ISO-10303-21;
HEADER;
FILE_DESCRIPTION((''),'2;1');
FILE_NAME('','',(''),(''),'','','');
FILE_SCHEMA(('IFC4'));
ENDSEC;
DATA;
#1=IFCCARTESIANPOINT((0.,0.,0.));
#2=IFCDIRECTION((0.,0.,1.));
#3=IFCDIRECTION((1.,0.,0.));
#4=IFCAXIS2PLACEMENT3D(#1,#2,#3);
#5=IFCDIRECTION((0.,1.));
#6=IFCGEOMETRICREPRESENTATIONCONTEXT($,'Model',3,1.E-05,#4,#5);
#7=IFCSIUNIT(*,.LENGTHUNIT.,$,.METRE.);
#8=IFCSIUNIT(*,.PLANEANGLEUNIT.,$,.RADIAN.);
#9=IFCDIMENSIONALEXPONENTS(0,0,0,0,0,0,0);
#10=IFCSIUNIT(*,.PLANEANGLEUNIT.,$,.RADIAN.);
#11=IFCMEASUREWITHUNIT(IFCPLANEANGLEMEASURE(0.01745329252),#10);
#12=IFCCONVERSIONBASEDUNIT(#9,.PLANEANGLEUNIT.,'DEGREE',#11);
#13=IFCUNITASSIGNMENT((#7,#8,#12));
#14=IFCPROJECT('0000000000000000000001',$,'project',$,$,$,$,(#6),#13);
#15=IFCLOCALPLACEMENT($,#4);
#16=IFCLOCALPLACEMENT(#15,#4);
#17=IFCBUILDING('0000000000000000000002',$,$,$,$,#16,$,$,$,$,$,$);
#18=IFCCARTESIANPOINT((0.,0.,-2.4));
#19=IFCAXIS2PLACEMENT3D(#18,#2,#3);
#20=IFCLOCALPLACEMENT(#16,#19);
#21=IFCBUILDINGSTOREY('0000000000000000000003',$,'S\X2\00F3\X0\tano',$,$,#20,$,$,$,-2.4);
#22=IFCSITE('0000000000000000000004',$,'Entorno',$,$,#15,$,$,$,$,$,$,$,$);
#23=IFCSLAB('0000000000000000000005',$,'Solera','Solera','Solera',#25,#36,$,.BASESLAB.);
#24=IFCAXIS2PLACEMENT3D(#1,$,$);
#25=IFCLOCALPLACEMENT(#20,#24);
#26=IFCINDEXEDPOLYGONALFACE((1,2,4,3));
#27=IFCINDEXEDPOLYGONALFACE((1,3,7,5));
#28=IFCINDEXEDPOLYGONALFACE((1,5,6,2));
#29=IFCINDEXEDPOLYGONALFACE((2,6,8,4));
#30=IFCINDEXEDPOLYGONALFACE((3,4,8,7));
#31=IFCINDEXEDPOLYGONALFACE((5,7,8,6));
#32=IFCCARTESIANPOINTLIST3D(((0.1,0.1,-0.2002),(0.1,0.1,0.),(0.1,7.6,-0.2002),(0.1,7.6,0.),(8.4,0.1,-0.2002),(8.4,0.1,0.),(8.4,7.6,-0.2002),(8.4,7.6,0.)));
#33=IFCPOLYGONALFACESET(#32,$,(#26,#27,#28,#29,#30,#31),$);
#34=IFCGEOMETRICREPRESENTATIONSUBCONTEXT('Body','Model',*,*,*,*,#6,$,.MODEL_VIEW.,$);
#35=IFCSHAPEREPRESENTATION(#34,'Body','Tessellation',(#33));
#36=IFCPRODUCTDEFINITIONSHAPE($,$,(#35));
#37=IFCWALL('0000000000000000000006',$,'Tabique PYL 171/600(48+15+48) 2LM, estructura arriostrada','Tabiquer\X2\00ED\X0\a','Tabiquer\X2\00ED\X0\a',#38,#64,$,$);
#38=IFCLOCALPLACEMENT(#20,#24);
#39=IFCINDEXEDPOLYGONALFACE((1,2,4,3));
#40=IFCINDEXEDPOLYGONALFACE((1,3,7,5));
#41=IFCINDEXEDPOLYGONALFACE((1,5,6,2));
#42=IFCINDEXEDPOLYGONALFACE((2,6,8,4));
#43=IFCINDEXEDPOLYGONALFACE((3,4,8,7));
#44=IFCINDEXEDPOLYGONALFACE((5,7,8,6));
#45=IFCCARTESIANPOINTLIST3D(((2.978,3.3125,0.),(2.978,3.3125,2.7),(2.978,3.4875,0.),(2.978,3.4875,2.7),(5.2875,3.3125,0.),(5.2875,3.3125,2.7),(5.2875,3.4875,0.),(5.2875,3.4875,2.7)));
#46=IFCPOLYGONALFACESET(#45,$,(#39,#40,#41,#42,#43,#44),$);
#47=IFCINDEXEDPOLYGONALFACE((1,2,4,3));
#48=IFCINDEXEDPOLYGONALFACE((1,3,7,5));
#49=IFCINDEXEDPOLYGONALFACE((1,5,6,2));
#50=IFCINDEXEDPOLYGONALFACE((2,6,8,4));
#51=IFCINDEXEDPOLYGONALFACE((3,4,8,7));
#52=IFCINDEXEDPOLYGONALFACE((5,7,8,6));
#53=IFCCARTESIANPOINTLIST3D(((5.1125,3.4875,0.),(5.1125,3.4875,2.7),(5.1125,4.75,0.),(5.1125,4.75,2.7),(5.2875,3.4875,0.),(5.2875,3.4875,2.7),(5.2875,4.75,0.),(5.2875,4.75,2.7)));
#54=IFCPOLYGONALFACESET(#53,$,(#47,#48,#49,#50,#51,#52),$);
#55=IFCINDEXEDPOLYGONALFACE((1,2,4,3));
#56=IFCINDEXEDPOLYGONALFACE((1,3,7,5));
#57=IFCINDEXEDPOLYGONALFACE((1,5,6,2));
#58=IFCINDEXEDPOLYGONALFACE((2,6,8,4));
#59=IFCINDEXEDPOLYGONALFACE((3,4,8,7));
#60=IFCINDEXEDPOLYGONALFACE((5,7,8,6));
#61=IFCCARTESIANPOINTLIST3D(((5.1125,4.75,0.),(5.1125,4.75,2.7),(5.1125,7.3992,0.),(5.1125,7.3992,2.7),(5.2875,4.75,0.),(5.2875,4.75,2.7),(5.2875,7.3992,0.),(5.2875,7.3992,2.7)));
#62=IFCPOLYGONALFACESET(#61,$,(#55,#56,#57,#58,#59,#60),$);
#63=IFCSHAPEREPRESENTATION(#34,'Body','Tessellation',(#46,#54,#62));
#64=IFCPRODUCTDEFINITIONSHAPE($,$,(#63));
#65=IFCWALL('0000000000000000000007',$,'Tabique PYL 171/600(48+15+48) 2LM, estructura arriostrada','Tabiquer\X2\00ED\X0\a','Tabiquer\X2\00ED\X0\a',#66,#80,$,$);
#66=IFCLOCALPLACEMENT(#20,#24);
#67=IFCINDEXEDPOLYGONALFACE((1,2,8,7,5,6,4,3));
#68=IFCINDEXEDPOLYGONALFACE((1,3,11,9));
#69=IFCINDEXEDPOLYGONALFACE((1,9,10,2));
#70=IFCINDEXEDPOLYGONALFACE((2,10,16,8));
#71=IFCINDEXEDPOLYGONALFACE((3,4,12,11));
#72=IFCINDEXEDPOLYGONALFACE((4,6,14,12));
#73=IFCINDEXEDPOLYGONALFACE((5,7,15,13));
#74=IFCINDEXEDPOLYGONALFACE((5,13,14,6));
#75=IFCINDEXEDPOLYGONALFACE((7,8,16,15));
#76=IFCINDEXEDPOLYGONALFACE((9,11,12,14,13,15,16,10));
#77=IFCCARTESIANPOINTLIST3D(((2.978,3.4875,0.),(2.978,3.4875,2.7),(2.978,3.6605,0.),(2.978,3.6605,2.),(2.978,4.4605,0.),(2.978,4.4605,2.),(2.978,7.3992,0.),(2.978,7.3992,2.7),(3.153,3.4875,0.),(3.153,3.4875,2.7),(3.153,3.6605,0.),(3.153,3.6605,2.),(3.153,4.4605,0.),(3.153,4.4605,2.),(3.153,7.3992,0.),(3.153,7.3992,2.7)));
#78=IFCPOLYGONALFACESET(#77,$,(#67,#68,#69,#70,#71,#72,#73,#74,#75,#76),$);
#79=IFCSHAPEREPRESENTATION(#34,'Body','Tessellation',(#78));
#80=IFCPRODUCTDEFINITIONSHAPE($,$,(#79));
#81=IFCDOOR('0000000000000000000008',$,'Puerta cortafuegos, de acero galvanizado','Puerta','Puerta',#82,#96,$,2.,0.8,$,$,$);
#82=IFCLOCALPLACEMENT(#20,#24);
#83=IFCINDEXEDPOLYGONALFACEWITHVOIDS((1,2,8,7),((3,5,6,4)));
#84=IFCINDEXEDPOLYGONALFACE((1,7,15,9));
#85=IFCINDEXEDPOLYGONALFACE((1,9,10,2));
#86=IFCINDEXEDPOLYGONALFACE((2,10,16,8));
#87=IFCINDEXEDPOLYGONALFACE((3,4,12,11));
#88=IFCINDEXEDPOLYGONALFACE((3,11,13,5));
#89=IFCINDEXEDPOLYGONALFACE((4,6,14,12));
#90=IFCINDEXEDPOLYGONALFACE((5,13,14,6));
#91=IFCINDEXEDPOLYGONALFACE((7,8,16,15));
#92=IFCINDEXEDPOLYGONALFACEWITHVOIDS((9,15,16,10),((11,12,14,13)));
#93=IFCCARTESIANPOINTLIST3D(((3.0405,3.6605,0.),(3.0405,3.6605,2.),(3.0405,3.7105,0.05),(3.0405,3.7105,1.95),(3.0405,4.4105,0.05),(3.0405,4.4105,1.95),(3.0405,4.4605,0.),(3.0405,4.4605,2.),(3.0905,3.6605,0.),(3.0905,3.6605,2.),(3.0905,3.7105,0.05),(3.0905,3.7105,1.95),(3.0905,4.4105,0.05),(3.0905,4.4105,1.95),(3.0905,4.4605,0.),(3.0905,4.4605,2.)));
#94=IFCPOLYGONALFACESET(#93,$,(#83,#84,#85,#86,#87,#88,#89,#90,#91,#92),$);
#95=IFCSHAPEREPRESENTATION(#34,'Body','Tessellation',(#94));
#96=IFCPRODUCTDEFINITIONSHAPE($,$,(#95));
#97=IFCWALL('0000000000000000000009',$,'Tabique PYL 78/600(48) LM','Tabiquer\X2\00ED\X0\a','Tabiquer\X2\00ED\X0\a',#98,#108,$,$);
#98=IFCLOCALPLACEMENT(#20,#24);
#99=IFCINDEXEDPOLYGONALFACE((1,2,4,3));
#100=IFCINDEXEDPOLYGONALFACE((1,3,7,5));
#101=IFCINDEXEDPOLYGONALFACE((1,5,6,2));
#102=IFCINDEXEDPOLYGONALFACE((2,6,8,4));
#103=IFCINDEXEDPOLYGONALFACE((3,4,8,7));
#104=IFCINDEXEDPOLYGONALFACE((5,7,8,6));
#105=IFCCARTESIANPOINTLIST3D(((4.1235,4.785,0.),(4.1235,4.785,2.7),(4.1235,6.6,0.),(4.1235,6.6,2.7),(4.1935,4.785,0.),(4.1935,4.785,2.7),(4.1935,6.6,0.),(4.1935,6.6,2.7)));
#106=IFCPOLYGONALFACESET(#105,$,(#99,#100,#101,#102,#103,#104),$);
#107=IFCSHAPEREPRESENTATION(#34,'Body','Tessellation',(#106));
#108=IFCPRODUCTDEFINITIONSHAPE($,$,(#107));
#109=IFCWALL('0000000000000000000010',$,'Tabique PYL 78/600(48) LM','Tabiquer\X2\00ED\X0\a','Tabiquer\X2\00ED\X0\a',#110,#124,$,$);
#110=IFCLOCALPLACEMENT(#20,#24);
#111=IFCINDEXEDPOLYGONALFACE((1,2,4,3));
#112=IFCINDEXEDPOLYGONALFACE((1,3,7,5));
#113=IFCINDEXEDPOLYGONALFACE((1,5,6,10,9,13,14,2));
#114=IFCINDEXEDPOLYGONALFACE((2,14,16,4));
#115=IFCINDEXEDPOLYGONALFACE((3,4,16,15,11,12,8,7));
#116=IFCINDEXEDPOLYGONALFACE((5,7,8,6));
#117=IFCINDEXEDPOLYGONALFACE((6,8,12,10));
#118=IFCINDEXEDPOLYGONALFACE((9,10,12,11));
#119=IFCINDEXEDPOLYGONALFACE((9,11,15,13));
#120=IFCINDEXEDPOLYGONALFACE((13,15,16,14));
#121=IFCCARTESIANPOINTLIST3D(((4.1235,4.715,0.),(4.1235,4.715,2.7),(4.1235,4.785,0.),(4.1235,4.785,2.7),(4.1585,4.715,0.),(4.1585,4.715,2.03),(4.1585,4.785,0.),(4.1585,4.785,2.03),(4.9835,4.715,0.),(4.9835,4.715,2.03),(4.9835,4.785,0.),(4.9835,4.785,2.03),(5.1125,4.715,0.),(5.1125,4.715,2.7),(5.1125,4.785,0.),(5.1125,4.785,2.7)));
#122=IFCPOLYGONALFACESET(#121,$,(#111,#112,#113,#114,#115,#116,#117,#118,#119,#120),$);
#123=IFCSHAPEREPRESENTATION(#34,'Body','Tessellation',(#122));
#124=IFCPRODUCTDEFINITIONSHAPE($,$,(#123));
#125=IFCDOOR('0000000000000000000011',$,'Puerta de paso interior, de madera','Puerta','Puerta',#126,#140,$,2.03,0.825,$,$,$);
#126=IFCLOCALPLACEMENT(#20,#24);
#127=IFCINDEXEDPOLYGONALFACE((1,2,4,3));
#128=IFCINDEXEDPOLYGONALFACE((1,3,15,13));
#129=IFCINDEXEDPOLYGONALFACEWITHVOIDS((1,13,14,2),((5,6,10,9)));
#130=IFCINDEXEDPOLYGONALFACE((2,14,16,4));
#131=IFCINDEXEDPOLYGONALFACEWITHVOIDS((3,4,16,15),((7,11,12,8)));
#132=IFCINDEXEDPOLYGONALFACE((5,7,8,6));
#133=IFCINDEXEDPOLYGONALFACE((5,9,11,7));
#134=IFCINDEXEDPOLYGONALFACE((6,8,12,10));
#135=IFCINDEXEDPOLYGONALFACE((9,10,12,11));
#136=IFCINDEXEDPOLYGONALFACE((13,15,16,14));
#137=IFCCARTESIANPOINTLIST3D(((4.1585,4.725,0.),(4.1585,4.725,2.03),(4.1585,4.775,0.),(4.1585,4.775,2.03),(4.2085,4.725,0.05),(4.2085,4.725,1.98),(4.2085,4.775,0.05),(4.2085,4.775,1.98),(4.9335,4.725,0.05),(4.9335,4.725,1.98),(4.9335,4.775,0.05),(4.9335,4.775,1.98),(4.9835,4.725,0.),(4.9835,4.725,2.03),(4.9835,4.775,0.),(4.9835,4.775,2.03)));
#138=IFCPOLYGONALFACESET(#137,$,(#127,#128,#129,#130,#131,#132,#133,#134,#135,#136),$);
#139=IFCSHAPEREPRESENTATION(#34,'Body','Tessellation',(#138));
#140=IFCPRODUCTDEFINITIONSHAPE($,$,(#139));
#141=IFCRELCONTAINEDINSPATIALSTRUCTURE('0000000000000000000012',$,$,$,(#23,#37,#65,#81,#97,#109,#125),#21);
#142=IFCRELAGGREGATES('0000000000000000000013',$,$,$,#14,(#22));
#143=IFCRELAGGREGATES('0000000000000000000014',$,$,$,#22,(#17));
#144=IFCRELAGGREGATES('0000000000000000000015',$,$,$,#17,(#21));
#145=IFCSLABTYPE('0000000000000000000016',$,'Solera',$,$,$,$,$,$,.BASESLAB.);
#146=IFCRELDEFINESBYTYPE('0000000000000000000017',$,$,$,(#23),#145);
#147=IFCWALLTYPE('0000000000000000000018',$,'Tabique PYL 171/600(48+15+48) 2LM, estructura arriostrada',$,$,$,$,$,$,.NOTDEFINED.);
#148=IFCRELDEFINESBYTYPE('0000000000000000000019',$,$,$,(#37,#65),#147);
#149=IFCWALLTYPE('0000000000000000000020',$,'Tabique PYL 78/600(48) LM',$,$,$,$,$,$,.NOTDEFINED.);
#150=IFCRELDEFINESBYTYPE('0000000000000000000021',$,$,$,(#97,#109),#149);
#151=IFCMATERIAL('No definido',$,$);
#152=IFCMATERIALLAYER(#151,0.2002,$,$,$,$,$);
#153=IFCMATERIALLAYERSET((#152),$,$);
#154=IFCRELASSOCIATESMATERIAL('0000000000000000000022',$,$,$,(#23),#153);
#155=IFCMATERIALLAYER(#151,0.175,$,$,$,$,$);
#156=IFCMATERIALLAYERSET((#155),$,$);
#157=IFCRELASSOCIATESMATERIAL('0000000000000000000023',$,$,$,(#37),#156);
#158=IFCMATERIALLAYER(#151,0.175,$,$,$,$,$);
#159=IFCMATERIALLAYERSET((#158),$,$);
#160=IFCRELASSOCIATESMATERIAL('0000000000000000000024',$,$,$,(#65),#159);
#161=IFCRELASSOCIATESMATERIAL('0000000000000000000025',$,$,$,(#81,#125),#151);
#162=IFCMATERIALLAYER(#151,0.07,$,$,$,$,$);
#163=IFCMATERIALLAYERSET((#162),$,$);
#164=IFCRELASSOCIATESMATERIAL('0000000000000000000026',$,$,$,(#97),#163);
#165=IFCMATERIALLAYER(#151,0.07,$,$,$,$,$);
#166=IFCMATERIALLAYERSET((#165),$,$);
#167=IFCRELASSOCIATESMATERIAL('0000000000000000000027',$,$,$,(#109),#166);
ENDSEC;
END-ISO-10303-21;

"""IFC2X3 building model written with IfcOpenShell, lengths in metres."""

from ifc_helpers import new_model, entity, si_unit, converted_unit, direction, frame, origin_with_axes, origin_2d_with_axis, place, context, subcontext, project, spatial, polyline, rectangle, hollow_rectangle, outline, extrude, shape, material, layer, layer_set, layer_usage, type_object, element, fill, save


model = new_model("IFC2X3")

# Units and contexts
model_context = context("Model", 3, precision=1e-05, world=origin_with_axes(), true_north=direction((0.0, 1.0)))
body_context = subcontext(model_context, "Body", "Model", "MODEL_VIEW")
footprint_context = subcontext(model_context, "FootPrint", "Model", "MODEL_VIEW")
ifc_project = project(units=[si_unit("LENGTHUNIT", "METRE"), si_unit("PLANEANGLEUNIT", "RADIAN"), converted_unit("PLANEANGLEUNIT", "DEGREE", entity("IfcPlaneAngleMeasure", 0.01745329252), si_unit("PLANEANGLEUNIT", "RADIAN"), dimensions=[0, 0, 0, 0, 0, 0, 0])], contexts=[model_context])

# Site, building, storey
site_placement = place(None, origin_with_axes())
site = spatial("IfcSite", under=ifc_project, at=site_placement, Name="Entorno")
building_placement = place(site_placement, origin_with_axes())
building = spatial("IfcBuilding", under=site, at=building_placement)
storey_placement = place(building_placement, frame((0.0, 0.0, -2.4), z_axis=(0.0, 0.0, 1.0), x_axis=(1.0, 0.0, 0.0)))
storey = spatial("IfcBuildingStorey", under=building, at=storey_placement, Name="Sótano", Elevation=-2.4)

# Slab
ifc_material = material(Name="No definido")
ifc_layer_1 = layer(ifc_material, 0.2002)
ifc_layer_set_1 = layer_set([ifc_layer_1])
ifc_layer_usage_1 = layer_usage(ifc_layer_set_1, "AXIS3", "POSITIVE", 0.0)
slab_type = type_object("IfcSlabType", Name="Solera", PredefinedType="BASESLAB")
slab_placement = place(storey_placement, frame((0.1, 0.1, -0.2002), z_axis=(0.0, 0.0, 1.0), x_axis=(1.0, 0.0, 0.0)))
element("IfcSlab", 1, at=slab_placement, inside=storey, type_object=slab_type, material=ifc_layer_usage_1, Name="Solera", Description="Solera", ObjectType="Solera", PredefinedType="BASESLAB", context=body_context, shape_type="SweptSolid", body=[
    extrude(outline(polyline([(0.0, 0.0), (8.3, 0.0), (8.3, 7.5), (0.0, 7.5), (0.0, 0.0)])), origin_with_axes(), (0.0, 0.0, 1.0), 0.2002),
])

# Wall
ifc_layer_2 = layer(ifc_material, 0.175)
ifc_layer_set_2 = layer_set([ifc_layer_2])
ifc_layer_usage_2 = layer_usage(ifc_layer_set_2, "AXIS2", "POSITIVE", -0.0875)
wall_type_1 = type_object("IfcWallType", Name="Tabique PYL 171/600(48+15+48) 2LM, estructura arriostrada")
wall_1_placement = place(storey_placement, frame((3.0655, 3.4, 0.0), z_axis=(0.0, 0.0, 1.0), x_axis=(1.0, 0.0, 0.0)))
element("IfcWall", 2, at=wall_1_placement, inside=storey, type_object=wall_type_1, material=ifc_layer_usage_2, Name="Tabique PYL 171/600(48+15+48) 2LM, estructura arriostrada", Description="Tabiquería", ObjectType="Tabiquería", context=body_context, shape_type="SolidModel", body=[
    extrude(outline(polyline([(-1.1547, -1.35), (1.1547, -1.35), (1.1547, 1.35), (-1.1547, 1.35), (-1.1547, -1.35)])), frame((1.0673, 0.0875, 1.35), z_axis=(0.0, -1.0, 0.0), x_axis=(1.0, 0.0, 0.0)), (0.0, 0.0, 1.0), 0.175),
    extrude(outline(polyline([(-0.6312, -1.35), (0.6312, -1.35), (0.6312, 1.35), (-0.6312, 1.35), (-0.6312, -1.35)])), frame((2.047, 0.7188, 1.35), z_axis=(1.0, 0.0, 0.0), x_axis=(0.0, 1.0, 0.0)), (0.0, 0.0, 1.0), 0.175),
    extrude(outline(polyline([(-1.3246, -1.35), (1.3246, -1.35), (1.3246, 1.35), (-1.3246, 1.35), (-1.3246, -1.35)])), frame((2.047, 2.6746, 1.35), z_axis=(1.0, 0.0, 0.0), x_axis=(0.0, 1.0, 0.0)), (0.0, 0.0, 1.0), 0.175),
])

# Wall, opening, door
ifc_layer_3 = layer(ifc_material, 0.175)
ifc_layer_set_3 = layer_set([ifc_layer_3])
ifc_layer_usage_3 = layer_usage(ifc_layer_set_3, "AXIS2", "POSITIVE", -0.0875)
wall_2_placement = place(storey_placement, frame((3.0655, 3.4, 0.0), z_axis=(0.0, 0.0, 1.0), x_axis=(0.0, 1.0, 0.0)))
wall_2 = element("IfcWall", 3, at=wall_2_placement, inside=storey, type_object=wall_type_1, material=ifc_layer_usage_3, Name="Tabique PYL 171/600(48+15+48) 2LM, estructura arriostrada", Description="Tabiquería", ObjectType="Tabiquería", context=body_context, shape_type="SolidModel", body=[
    extrude(outline(polyline([(-1.9559, -1.35), (1.9559, -1.35), (1.9559, 1.35), (-1.9559, 1.35), (-1.9559, -1.35)])), frame((2.0434, 0.0875, 1.35), z_axis=(0.0, -1.0, 0.0), x_axis=(1.0, 0.0, 0.0)), (0.0, 0.0, 1.0), 0.175),
])
opening_1_placement = place(wall_2_placement, frame((0.6605, 0.0, 1.0), z_axis=(0.0, 0.0, 1.0), x_axis=(1.0, 0.0, 0.0)))
cartesian_point_1 = entity("IfcCartesianPoint", [-0.4, -0.0875])
opening_1 = element("IfcOpeningElement", 4, at=opening_1_placement, cuts=wall_2, ObjectType="No definido", shapes=[
    shape(body_context, "Body", "SweptSolid", [extrude(rectangle(XDim=2.0, YDim=0.8, at=origin_2d_with_axis()), frame((0.0, -0.0875, 0.0), z_axis=(0.0, 1.0, 0.0), x_axis=(0.0, 0.0, 1.0)), (0.0, 0.0, 1.0), 0.175)]),
    shape(footprint_context, "FootPrint", "GeometricCurveSet", [entity("IfcGeometricCurveSet", [entity("IfcPolyline", [cartesian_point_1, entity("IfcCartesianPoint", [0.4, -0.0875]), entity("IfcCartesianPoint", [0.4, 0.0875]), entity("IfcCartesianPoint", [-0.4, 0.0875]), cartesian_point_1])])]),
])
door_1_placement = place(opening_1_placement, origin_with_axes())
door_1 = element("IfcDoor", 5, at=door_1_placement, inside=storey, material=ifc_material, Name="Puerta cortafuegos, de acero galvanizado", Description="Puerta", ObjectType="Puerta", OverallHeight=2.0, OverallWidth=0.8, context=body_context, shape_type="SweptSolid", body=[
    extrude(hollow_rectangle(XDim=0.8, YDim=2.0, WallThickness=0.05, InnerFilletRadius=0.0, OuterFilletRadius=0.0, at=origin_2d_with_axis()), frame((0.0, 0.025, 0.0), z_axis=(0.0, -1.0, 0.0), x_axis=(1.0, 0.0, 0.0)), (0.0, 0.0, 1.0), 0.05),
])
fill(opening_1, door_1)

# Wall
ifc_layer_4 = layer(ifc_material, 0.07)
ifc_layer_set_4 = layer_set([ifc_layer_4])
ifc_layer_usage_4 = layer_usage(ifc_layer_set_4, "AXIS2", "POSITIVE", -0.035)
wall_type_2 = type_object("IfcWallType", Name="Tabique PYL 78/600(48) LM")
wall_3_placement = place(storey_placement, frame((4.1585, 4.75, 0.0), z_axis=(0.0, 0.0, 1.0), x_axis=(0.0, 1.0, 0.0)))
element("IfcWall", 6, at=wall_3_placement, inside=storey, type_object=wall_type_2, material=ifc_layer_usage_4, Name="Tabique PYL 78/600(48) LM", Description="Tabiquería", ObjectType="Tabiquería", context=body_context, shape_type="SolidModel", body=[
    extrude(outline(polyline([(-0.9075, -1.35), (0.9075, -1.35), (0.9075, 1.35), (-0.9075, 1.35), (-0.9075, -1.35)])), frame((0.9425, 0.035, 1.35), z_axis=(0.0, -1.0, 0.0), x_axis=(1.0, 0.0, 0.0)), (0.0, 0.0, 1.0), 0.07),
])

# Wall, opening, door
ifc_layer_5 = layer(ifc_material, 0.07)
ifc_layer_set_5 = layer_set([ifc_layer_5])
ifc_layer_usage_5 = layer_usage(ifc_layer_set_5, "AXIS2", "POSITIVE", -0.035)
wall_4_placement = place(storey_placement, frame((4.1585, 4.75, 0.0), z_axis=(0.0, 0.0, 1.0), x_axis=(1.0, 0.0, 0.0)))
wall_4 = element("IfcWall", 7, at=wall_4_placement, inside=storey, type_object=wall_type_2, material=ifc_layer_usage_5, Name="Tabique PYL 78/600(48) LM", Description="Tabiquería", ObjectType="Tabiquería", context=body_context, shape_type="SolidModel", body=[
    extrude(outline(polyline([(-0.4945, -1.35), (0.4945, -1.35), (0.4945, 1.35), (-0.4945, 1.35), (-0.4945, -1.35)])), frame((0.4595, 0.035, 1.35), z_axis=(0.0, -1.0, 0.0), x_axis=(1.0, 0.0, 0.0)), (0.0, 0.0, 1.0), 0.07),
])
opening_2_placement = place(wall_4_placement, frame((0.4125, 0.0, 1.015), z_axis=(0.0, 0.0, 1.0), x_axis=(1.0, 0.0, 0.0)))
cartesian_point_2 = entity("IfcCartesianPoint", [-0.4125, -0.035])
opening_2 = element("IfcOpeningElement", 8, at=opening_2_placement, cuts=wall_4, ObjectType="No definido", shapes=[
    shape(body_context, "Body", "SweptSolid", [extrude(rectangle(XDim=2.03, YDim=0.825, at=origin_2d_with_axis()), frame((0.0, -0.035, 0.0), z_axis=(0.0, 1.0, 0.0), x_axis=(0.0, 0.0, 1.0)), (0.0, 0.0, 1.0), 0.07)]),
    shape(footprint_context, "FootPrint", "GeometricCurveSet", [entity("IfcGeometricCurveSet", [entity("IfcPolyline", [cartesian_point_2, entity("IfcCartesianPoint", [0.4125, -0.035]), entity("IfcCartesianPoint", [0.4125, 0.035]), entity("IfcCartesianPoint", [-0.4125, 0.035]), cartesian_point_2])])]),
])
door_2_placement = place(opening_2_placement, origin_with_axes())
door_2 = element("IfcDoor", 9, at=door_2_placement, inside=storey, material=ifc_material, Name="Puerta de paso interior, de madera", Description="Puerta", ObjectType="Puerta", OverallHeight=2.03, OverallWidth=0.825, context=body_context, shape_type="SweptSolid", body=[
    extrude(hollow_rectangle(XDim=0.825, YDim=2.03, WallThickness=0.05, InnerFilletRadius=0.0, OuterFilletRadius=0.0, at=origin_2d_with_axis()), frame((0.0, 0.025, 0.0), z_axis=(0.0, -1.0, 0.0), x_axis=(1.0, 0.0, 0.0)), (0.0, 0.0, 1.0), 0.05),
])
fill(opening_2, door_2)

save(model, "model.ifc")
